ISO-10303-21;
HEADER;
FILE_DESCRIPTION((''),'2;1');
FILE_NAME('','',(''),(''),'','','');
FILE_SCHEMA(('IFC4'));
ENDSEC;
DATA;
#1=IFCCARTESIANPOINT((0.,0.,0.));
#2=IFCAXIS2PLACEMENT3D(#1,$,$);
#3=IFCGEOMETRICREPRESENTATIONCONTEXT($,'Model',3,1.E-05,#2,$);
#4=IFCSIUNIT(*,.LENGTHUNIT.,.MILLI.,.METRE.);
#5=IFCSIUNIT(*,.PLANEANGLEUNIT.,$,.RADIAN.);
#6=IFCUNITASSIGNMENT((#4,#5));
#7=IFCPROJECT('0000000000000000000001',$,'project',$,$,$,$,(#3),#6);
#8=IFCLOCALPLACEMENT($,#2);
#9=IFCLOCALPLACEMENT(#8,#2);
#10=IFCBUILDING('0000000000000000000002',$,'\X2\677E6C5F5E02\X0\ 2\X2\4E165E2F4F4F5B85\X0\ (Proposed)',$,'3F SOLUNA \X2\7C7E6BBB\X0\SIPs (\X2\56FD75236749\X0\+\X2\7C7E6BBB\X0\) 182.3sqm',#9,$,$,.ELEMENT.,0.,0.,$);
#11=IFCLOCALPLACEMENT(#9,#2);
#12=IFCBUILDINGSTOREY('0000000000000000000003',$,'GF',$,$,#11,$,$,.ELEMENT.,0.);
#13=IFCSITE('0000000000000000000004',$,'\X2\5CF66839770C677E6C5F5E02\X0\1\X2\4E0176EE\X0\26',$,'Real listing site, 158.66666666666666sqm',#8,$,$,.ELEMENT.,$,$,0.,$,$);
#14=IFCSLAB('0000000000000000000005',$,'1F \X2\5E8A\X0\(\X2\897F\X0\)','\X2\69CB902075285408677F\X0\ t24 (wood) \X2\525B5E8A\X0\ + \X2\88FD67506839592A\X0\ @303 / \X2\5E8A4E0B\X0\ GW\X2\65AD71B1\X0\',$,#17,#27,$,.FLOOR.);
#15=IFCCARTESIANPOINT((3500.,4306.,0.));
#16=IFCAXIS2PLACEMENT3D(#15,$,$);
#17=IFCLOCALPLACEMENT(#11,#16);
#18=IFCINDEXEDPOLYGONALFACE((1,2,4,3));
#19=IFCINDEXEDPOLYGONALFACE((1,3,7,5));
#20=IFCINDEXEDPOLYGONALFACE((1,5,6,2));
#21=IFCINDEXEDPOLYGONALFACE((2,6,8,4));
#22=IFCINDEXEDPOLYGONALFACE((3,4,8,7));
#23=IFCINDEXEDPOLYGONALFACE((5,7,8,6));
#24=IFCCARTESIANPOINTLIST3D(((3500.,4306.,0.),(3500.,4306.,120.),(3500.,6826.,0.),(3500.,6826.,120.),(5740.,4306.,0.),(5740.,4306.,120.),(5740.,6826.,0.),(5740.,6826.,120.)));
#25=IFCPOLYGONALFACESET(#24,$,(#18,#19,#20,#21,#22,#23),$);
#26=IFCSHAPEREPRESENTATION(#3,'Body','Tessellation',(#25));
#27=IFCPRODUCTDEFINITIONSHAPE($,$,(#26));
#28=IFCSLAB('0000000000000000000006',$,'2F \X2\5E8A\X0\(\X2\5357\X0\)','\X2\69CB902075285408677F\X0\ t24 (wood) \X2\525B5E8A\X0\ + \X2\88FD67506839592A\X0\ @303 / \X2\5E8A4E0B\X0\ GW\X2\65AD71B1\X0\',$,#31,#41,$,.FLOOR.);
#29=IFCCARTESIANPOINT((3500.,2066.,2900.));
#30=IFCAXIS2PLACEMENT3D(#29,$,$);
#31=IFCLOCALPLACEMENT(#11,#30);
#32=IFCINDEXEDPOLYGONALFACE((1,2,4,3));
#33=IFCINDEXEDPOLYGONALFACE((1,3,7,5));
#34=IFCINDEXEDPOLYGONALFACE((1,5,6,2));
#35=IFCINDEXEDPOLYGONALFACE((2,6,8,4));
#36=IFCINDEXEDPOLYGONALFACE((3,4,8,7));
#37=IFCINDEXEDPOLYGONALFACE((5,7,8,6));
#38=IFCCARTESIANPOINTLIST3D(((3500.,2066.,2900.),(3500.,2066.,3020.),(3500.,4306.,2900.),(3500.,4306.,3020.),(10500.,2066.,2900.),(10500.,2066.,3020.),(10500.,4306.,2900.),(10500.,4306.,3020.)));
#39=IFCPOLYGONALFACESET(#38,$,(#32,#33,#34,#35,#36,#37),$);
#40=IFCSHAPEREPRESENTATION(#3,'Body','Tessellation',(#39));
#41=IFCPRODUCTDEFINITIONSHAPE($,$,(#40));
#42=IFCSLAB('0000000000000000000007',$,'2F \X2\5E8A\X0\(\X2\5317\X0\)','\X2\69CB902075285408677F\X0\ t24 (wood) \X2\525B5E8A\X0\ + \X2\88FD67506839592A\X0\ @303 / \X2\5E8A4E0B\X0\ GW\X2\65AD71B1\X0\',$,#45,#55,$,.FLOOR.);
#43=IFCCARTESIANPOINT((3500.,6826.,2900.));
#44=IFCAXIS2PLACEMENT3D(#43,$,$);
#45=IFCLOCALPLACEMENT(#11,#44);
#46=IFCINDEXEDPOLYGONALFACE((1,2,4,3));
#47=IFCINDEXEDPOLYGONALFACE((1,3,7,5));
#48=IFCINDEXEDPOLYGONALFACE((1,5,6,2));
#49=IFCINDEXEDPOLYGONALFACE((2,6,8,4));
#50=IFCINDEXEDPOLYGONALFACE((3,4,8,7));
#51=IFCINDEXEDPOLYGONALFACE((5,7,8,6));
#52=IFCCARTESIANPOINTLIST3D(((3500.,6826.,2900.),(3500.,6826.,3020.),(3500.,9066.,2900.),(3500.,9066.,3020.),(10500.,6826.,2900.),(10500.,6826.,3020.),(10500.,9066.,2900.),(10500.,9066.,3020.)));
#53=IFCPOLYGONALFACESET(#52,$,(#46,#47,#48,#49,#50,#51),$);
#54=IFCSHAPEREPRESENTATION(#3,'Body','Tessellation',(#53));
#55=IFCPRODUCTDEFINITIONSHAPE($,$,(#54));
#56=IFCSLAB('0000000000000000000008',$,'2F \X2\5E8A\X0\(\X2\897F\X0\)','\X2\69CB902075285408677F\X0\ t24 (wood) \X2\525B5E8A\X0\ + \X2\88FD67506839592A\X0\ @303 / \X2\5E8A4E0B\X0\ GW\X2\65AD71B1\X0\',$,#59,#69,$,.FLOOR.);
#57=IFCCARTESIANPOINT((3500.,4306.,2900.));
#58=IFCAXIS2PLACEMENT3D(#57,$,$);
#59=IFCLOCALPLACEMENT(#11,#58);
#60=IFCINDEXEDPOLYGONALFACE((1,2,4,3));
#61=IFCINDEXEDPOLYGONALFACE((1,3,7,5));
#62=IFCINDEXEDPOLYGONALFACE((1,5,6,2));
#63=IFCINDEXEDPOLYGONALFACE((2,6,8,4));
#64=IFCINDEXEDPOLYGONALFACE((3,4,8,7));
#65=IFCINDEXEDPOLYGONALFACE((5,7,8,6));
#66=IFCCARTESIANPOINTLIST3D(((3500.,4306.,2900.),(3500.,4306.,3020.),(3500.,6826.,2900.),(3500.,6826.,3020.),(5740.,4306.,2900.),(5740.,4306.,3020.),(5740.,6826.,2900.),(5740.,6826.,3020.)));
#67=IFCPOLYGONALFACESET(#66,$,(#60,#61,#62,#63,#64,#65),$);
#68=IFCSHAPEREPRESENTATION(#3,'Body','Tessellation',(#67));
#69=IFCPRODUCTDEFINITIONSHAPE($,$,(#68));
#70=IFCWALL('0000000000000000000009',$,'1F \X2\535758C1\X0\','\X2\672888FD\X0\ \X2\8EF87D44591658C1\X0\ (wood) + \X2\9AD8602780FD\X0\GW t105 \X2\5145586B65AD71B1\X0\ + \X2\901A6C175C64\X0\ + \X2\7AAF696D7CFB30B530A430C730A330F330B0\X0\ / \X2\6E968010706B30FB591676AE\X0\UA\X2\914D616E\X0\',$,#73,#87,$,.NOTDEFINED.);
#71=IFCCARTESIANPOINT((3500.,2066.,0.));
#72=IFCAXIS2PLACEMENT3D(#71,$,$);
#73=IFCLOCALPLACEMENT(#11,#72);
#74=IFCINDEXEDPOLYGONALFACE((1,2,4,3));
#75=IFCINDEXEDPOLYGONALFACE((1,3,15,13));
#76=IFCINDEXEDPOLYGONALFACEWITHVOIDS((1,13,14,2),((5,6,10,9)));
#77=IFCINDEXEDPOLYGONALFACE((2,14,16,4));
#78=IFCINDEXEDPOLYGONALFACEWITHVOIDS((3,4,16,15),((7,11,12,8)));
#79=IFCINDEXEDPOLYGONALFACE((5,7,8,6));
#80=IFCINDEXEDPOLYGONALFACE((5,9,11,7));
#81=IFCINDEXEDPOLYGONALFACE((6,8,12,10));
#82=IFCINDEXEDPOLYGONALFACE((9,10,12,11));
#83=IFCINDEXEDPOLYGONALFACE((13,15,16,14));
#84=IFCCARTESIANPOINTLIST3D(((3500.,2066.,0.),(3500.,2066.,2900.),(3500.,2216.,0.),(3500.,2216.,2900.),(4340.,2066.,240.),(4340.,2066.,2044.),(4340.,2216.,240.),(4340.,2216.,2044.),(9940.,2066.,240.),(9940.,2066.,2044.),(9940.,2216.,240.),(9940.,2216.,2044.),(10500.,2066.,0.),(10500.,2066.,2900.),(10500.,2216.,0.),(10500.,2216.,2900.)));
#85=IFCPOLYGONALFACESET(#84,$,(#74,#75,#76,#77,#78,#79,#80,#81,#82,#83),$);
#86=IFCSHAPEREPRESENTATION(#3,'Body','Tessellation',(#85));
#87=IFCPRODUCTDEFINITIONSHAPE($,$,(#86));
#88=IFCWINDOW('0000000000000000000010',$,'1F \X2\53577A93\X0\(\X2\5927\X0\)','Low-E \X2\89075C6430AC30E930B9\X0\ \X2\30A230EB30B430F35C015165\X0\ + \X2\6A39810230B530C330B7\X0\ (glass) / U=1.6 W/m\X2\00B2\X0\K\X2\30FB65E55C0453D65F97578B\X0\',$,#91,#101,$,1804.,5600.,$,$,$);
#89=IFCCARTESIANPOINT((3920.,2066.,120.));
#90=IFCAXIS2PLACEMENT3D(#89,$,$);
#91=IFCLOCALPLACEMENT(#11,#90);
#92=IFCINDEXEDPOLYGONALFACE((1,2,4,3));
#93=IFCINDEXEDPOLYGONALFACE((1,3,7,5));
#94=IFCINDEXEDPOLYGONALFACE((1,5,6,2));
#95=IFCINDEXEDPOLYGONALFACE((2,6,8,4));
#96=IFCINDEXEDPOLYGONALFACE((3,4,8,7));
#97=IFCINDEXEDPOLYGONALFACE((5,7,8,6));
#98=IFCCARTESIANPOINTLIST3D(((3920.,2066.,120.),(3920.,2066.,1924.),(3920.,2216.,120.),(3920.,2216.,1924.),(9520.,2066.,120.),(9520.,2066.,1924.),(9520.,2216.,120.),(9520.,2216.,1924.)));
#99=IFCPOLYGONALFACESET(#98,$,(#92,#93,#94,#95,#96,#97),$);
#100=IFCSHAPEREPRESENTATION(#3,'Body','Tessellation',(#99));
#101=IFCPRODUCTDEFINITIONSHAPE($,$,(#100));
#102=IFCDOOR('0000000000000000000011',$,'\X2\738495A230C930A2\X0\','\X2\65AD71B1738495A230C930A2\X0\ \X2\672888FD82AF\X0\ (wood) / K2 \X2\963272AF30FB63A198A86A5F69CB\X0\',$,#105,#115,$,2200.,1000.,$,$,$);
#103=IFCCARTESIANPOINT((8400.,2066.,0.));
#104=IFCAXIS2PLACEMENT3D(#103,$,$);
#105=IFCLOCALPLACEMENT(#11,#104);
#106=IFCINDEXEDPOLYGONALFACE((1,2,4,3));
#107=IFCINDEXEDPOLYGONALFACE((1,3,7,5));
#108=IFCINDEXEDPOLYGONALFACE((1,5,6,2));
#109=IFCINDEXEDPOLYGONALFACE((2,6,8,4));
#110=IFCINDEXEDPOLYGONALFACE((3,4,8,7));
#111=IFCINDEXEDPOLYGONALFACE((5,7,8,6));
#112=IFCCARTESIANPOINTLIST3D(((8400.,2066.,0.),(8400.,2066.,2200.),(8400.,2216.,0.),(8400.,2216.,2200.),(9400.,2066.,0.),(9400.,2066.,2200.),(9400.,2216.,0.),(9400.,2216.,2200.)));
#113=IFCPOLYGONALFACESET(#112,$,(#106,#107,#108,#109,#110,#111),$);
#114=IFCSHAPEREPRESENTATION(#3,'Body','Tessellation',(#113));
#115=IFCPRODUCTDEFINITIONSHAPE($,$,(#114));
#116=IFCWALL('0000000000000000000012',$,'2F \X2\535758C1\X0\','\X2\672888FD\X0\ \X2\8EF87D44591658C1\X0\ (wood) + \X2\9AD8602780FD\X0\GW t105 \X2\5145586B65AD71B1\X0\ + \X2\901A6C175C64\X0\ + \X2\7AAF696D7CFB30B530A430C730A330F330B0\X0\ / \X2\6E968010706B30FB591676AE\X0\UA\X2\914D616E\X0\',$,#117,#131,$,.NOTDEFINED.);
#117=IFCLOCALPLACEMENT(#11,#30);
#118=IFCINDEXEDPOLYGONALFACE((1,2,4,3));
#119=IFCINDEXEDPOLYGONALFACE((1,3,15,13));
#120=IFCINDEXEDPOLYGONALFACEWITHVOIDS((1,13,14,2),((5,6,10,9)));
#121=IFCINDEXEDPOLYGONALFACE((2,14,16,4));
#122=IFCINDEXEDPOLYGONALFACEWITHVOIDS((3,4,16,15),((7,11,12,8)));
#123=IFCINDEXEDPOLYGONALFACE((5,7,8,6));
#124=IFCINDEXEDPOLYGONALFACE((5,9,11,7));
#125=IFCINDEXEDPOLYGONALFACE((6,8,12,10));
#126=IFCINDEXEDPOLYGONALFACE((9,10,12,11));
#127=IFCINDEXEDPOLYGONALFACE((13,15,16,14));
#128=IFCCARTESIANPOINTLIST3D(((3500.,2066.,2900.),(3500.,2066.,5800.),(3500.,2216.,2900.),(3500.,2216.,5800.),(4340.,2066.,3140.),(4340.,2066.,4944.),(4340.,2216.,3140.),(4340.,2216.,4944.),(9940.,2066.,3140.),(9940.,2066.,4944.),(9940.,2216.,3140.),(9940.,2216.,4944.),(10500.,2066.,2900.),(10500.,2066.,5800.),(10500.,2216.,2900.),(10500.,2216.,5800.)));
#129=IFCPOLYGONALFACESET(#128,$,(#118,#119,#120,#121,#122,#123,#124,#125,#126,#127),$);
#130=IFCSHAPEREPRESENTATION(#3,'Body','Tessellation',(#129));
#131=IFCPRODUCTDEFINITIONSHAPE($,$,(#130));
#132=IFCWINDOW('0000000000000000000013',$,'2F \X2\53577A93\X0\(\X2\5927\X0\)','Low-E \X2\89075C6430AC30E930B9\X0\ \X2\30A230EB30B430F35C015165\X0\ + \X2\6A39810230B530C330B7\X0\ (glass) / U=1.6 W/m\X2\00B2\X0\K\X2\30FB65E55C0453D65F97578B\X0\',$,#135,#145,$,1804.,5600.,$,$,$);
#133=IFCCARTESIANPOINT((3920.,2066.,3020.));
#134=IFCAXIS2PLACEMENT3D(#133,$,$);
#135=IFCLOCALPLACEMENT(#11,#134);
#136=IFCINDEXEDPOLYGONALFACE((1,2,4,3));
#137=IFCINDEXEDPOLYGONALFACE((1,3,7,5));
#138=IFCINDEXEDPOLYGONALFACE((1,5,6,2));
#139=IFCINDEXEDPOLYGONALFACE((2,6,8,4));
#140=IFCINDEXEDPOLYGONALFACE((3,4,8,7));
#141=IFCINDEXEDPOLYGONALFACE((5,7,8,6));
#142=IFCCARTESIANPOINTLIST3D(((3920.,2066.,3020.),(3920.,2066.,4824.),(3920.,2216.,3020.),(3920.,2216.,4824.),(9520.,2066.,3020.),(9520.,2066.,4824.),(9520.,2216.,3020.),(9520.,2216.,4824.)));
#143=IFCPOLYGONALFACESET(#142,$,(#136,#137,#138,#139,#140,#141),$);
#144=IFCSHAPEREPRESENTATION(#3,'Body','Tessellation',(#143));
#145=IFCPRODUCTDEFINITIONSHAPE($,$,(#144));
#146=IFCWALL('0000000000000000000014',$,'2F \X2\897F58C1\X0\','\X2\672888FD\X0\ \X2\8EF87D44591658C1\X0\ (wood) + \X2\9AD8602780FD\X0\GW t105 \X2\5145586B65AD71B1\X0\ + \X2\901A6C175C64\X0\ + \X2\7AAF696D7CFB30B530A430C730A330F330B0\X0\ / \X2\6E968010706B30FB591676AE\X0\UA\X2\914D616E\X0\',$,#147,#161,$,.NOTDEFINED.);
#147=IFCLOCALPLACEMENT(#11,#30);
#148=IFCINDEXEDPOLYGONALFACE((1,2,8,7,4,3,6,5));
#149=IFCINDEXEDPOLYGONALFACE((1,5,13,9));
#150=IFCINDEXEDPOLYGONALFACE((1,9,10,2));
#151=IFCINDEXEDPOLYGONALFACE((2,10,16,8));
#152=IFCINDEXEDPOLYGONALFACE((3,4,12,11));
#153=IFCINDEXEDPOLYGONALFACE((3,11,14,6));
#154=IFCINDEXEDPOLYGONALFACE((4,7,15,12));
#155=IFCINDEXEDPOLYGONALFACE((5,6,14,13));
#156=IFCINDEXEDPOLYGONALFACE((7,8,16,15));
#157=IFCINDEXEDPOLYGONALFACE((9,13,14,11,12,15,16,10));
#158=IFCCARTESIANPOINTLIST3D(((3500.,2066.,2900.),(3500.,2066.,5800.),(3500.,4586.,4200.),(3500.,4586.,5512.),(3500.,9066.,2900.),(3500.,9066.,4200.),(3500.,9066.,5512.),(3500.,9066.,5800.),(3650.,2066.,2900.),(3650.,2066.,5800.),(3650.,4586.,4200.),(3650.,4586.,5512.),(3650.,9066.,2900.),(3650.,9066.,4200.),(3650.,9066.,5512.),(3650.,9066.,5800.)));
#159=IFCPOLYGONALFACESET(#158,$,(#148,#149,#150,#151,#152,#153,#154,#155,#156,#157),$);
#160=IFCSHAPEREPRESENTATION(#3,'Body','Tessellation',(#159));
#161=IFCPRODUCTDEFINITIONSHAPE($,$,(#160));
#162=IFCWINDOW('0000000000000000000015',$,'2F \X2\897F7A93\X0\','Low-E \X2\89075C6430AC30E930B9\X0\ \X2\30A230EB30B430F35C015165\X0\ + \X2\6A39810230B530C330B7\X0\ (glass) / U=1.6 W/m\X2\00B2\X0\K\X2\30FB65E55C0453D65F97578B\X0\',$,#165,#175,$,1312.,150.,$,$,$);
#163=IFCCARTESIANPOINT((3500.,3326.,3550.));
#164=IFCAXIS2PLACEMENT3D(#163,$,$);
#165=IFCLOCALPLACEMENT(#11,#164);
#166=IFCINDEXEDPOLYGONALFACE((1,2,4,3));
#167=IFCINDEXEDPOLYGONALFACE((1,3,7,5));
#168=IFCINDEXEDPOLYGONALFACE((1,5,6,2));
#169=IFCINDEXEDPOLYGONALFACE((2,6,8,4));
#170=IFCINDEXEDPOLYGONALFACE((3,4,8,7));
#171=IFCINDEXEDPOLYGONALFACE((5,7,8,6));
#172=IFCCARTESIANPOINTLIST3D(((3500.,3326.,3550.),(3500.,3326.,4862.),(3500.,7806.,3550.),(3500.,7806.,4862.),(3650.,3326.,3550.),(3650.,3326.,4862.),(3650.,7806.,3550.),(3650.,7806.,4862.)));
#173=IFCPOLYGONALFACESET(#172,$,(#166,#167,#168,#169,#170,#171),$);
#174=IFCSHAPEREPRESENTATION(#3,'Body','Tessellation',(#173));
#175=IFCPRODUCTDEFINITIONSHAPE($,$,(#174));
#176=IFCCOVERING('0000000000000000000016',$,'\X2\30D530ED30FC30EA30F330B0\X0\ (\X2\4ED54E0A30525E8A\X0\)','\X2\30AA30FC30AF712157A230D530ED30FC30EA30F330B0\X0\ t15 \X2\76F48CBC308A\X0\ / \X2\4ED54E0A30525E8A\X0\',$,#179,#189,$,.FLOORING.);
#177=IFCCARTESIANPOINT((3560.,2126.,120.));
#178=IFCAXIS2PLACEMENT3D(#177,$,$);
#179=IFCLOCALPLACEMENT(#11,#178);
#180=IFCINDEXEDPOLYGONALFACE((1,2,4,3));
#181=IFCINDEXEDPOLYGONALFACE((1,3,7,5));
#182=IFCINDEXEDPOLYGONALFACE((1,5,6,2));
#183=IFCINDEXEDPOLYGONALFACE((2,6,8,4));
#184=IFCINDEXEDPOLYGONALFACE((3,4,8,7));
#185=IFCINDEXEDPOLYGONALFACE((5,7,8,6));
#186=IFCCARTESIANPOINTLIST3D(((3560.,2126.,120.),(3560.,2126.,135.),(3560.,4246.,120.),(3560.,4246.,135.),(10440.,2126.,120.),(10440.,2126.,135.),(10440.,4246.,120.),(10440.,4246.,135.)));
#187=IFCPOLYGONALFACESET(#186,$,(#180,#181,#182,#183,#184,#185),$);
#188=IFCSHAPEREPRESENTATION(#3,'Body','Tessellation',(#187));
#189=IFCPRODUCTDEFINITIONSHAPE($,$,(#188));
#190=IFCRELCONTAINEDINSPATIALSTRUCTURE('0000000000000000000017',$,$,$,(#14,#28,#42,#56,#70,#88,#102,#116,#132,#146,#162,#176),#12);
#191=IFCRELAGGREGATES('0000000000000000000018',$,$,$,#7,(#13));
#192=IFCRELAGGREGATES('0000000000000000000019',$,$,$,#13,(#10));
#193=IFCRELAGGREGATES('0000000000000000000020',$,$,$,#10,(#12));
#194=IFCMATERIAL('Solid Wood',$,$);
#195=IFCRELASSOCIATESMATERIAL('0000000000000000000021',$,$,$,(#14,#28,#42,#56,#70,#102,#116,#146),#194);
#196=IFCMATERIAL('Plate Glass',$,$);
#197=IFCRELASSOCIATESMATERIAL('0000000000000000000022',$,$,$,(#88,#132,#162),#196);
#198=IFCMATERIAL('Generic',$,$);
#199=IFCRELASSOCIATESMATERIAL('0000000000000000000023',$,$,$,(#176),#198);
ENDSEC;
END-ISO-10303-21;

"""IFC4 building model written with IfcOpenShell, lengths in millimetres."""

from ifc_helpers import new_model, si_unit, frame, frame_2d, origin, place, context, project, spatial, rectangle, extrude, material, element, fill, save


model = new_model("IFC4")

# Units and contexts
model_context = context("Model", 3, precision=1e-05, world=origin())
ifc_project = project(units=[si_unit("LENGTHUNIT", "METRE", prefix="MILLI"), si_unit("PLANEANGLEUNIT", "RADIAN")], contexts=[model_context])

# Site, building, storey
site_placement = place(None, origin())
site = spatial("IfcSite", under=ifc_project, at=site_placement, Name="島根県松江市1丁目26", ObjectType="Real listing site, 158.66666666666666sqm", CompositionType="ELEMENT", RefElevation=0.0)
building_placement = place(site_placement, origin())
building = spatial("IfcBuilding", under=site, at=building_placement, Name="松江市 2世帯住宅 (Proposed)", ObjectType="3F SOLUNA 籾殻SIPs (国産杉+籾殻) 182.3sqm", CompositionType="ELEMENT", ElevationOfRefHeight=0.0, ElevationOfTerrain=0.0)
storey_placement = place(building_placement, origin())
storey = spatial("IfcBuildingStorey", under=building, at=storey_placement, Name="GF", CompositionType="ELEMENT", Elevation=0.0)

# Slabs
ifc_material_1 = material(Name="Solid Wood")
slab_1_placement = place(storey_placement, frame((3500.0, 4306.0, 0.0)))
element("IfcSlab", 1, at=slab_1_placement, inside=storey, material=ifc_material_1, Name="1F 床(西)", Description="構造用合板 t24 (wood) 剛床 + 製材根太 @303 / 床下 GW断熱", PredefinedType="FLOOR", context=model_context, shape_type="SweptSolid", body=[
    extrude(rectangle(XDim=2240.0, YDim=2520.0, at=frame_2d((1120.0, 1260.0))), frame((3500.0, 4306.0, 0.0)), (0.0, 0.0, 1.0), 120.0),
])
slab_2_placement = place(storey_placement, frame((3500.0, 2066.0, 2900.0)))
element("IfcSlab", 2, at=slab_2_placement, inside=storey, material=ifc_material_1, Name="2F 床(南)", Description="構造用合板 t24 (wood) 剛床 + 製材根太 @303 / 床下 GW断熱", PredefinedType="FLOOR", context=model_context, shape_type="SweptSolid", body=[
    extrude(rectangle(XDim=7000.0, YDim=2240.0, at=frame_2d((3500.0, 1120.0))), frame((3500.0, 2066.0, 2900.0)), (0.0, 0.0, 1.0), 120.0),
])
slab_3_placement = place(storey_placement, frame((3500.0, 6826.0, 2900.0)))
element("IfcSlab", 3, at=slab_3_placement, inside=storey, material=ifc_material_1, Name="2F 床(北)", Description="構造用合板 t24 (wood) 剛床 + 製材根太 @303 / 床下 GW断熱", PredefinedType="FLOOR", context=model_context, shape_type="SweptSolid", body=[
    extrude(rectangle(XDim=7000.0, YDim=2240.0, at=frame_2d((3500.0, 1120.0))), frame((3500.0, 6826.0, 2900.0)), (0.0, 0.0, 1.0), 120.0),
])
slab_4_placement = place(storey_placement, frame((3500.0, 4306.0, 2900.0)))
element("IfcSlab", 4, at=slab_4_placement, inside=storey, material=ifc_material_1, Name="2F 床(西)", Description="構造用合板 t24 (wood) 剛床 + 製材根太 @303 / 床下 GW断熱", PredefinedType="FLOOR", context=model_context, shape_type="SweptSolid", body=[
    extrude(rectangle(XDim=2240.0, YDim=2520.0, at=frame_2d((1120.0, 1260.0))), frame((3500.0, 4306.0, 2900.0)), (0.0, 0.0, 1.0), 120.0),
])

# Wall, openings, window, door
wall_1_placement = place(storey_placement, frame((3500.0, 2066.0, 0.0)))
wall_1 = element("IfcWall", 5, at=wall_1_placement, inside=storey, material=ifc_material_1, Name="1F 南壁", Description="木製 軸組外壁 (wood) + 高性能GW t105 充填断熱 + 通気層 + 窯業系サイディング / 準耐火・外皮UA配慮", PredefinedType="NOTDEFINED", context=model_context, shape_type="SweptSolid", body=[
    extrude(rectangle(XDim=7000.0, YDim=150.0, at=frame_2d((3500.0, 75.0))), frame((3500.0, 2066.0, 0.0)), (0.0, 0.0, 1.0), 2900.0),
])
opening_1_placement = place(storey_placement, frame((3920.0, 2066.0, 120.0)))
opening_1 = element("IfcOpeningElement", 6, at=opening_1_placement, cuts=wall_1, PredefinedType="NOTDEFINED", context=model_context, shape_type="SweptSolid", body=[
    extrude(rectangle(XDim=5600.0, YDim=150.0, at=frame_2d((2800.0, 75.0))), frame((3920.0, 2066.0, 120.0)), (0.0, 0.0, 1.0), 1804.0),
])
opening_2_placement = place(storey_placement, frame((8400.0, 2066.0, 0.0)))
opening_2 = element("IfcOpeningElement", 7, at=opening_2_placement, cuts=wall_1, PredefinedType="NOTDEFINED", context=model_context, shape_type="SweptSolid", body=[
    extrude(rectangle(XDim=1000.0, YDim=150.0, at=frame_2d((500.0, 75.0))), frame((8400.0, 2066.0, 0.0)), (0.0, 0.0, 1.0), 2200.0),
])
ifc_material_2 = material(Name="Plate Glass")
window_1_placement = place(storey_placement, frame((3920.0, 2066.0, 120.0)))
window_1 = element("IfcWindow", 8, at=window_1_placement, inside=storey, material=ifc_material_2, Name="1F 南窓(大)", Description="Low-E 複層ガラス アルゴン封入 + 樹脂サッシ (glass) / U=1.6 W/m²K・日射取得型", OverallHeight=1804.0, OverallWidth=5600.0, context=model_context, shape_type="SweptSolid", body=[
    extrude(rectangle(XDim=5600.0, YDim=150.0, at=frame_2d((2800.0, 75.0))), frame((3920.0, 2066.0, 120.0)), (0.0, 0.0, 1.0), 1804.0),
])
fill(opening_1, window_1)
door_placement = place(storey_placement, frame((8400.0, 2066.0, 0.0)))
door = element("IfcDoor", 9, at=door_placement, inside=storey, material=ifc_material_1, Name="玄関ドア", Description="断熱玄関ドア 木製芯 (wood) / K2 防犯・採風機構", OverallHeight=2200.0, OverallWidth=1000.0, context=model_context, shape_type="SweptSolid", body=[
    extrude(rectangle(XDim=1000.0, YDim=150.0, at=frame_2d((500.0, 75.0))), frame((8400.0, 2066.0, 0.0)), (0.0, 0.0, 1.0), 2200.0),
])
fill(opening_2, door)

# Wall, opening, window
wall_2_placement = place(storey_placement, frame((3500.0, 2066.0, 2900.0)))
wall_2 = element("IfcWall", 10, at=wall_2_placement, inside=storey, material=ifc_material_1, Name="2F 南壁", Description="木製 軸組外壁 (wood) + 高性能GW t105 充填断熱 + 通気層 + 窯業系サイディング / 準耐火・外皮UA配慮", PredefinedType="NOTDEFINED", context=model_context, shape_type="SweptSolid", body=[
    extrude(rectangle(XDim=7000.0, YDim=150.0, at=frame_2d((3500.0, 75.0))), frame((3500.0, 2066.0, 2900.0)), (0.0, 0.0, 1.0), 2900.0),
])
opening_3_placement = place(storey_placement, frame((3920.0, 2066.0, 3020.0)))
opening_3 = element("IfcOpeningElement", 11, at=opening_3_placement, cuts=wall_2, PredefinedType="NOTDEFINED", context=model_context, shape_type="SweptSolid", body=[
    extrude(rectangle(XDim=5600.0, YDim=150.0, at=frame_2d((2800.0, 75.0))), frame((3920.0, 2066.0, 3020.0)), (0.0, 0.0, 1.0), 1804.0),
])
window_2_placement = place(storey_placement, frame((3920.0, 2066.0, 3020.0)))
window_2 = element("IfcWindow", 12, at=window_2_placement, inside=storey, material=ifc_material_2, Name="2F 南窓(大)", Description="Low-E 複層ガラス アルゴン封入 + 樹脂サッシ (glass) / U=1.6 W/m²K・日射取得型", OverallHeight=1804.0, OverallWidth=5600.0, context=model_context, shape_type="SweptSolid", body=[
    extrude(rectangle(XDim=5600.0, YDim=150.0, at=frame_2d((2800.0, 75.0))), frame((3920.0, 2066.0, 3020.0)), (0.0, 0.0, 1.0), 1804.0),
])
fill(opening_3, window_2)

# Wall, opening, window
wall_3_placement = place(storey_placement, frame((3500.0, 2066.0, 2900.0)))
wall_3 = element("IfcWall", 13, at=wall_3_placement, inside=storey, material=ifc_material_1, Name="2F 西壁", Description="木製 軸組外壁 (wood) + 高性能GW t105 充填断熱 + 通気層 + 窯業系サイディング / 準耐火・外皮UA配慮", PredefinedType="NOTDEFINED", context=model_context, shape_type="SweptSolid", body=[
    extrude(rectangle(XDim=150.0, YDim=7000.0, at=frame_2d((75.0, 3500.0))), frame((3500.0, 2066.0, 2900.0)), (0.0, 0.0, 1.0), 2900.0),
])
opening_4_placement = place(storey_placement, frame((3500.0, 3326.0, 3550.0)))
opening_4 = element("IfcOpeningElement", 14, at=opening_4_placement, cuts=wall_3, PredefinedType="NOTDEFINED", context=model_context, shape_type="SweptSolid", body=[
    extrude(rectangle(XDim=150.0, YDim=4480.0, at=frame_2d((75.0, 2240.0))), frame((3500.0, 3326.0, 3550.0)), (0.0, 0.0, 1.0), 1312.0),
])
window_3_placement = place(storey_placement, frame((3500.0, 3326.0, 3550.0)))
window_3 = element("IfcWindow", 15, at=window_3_placement, inside=storey, material=ifc_material_2, Name="2F 西窓", Description="Low-E 複層ガラス アルゴン封入 + 樹脂サッシ (glass) / U=1.6 W/m²K・日射取得型", OverallHeight=1312.0, OverallWidth=150.0, context=model_context, shape_type="SweptSolid", body=[
    extrude(rectangle(XDim=150.0, YDim=4480.0, at=frame_2d((75.0, 2240.0))), frame((3500.0, 3326.0, 3550.0)), (0.0, 0.0, 1.0), 1312.0),
])
fill(opening_4, window_3)

# Covering
ifc_material_3 = material(Name="Generic")
covering_1_placement = place(storey_placement, frame((3560.0, 2126.0, 120.0)))
element("IfcCovering", 16, at=covering_1_placement, inside=storey, material=ifc_material_3, Name="フローリング (仕上げ床)", Description="オーク無垢フローリング t15 直貼り / 仕上げ床", PredefinedType="FLOORING", context=model_context, shape_type="SweptSolid", body=[
    extrude(rectangle(XDim=6880.0, YDim=2120.0, at=frame_2d((3440.0, 1060.0))), frame((3560.0, 2126.0, 120.0)), (0.0, 0.0, 1.0), 15.0),
])

save(model, "model.ifc")
